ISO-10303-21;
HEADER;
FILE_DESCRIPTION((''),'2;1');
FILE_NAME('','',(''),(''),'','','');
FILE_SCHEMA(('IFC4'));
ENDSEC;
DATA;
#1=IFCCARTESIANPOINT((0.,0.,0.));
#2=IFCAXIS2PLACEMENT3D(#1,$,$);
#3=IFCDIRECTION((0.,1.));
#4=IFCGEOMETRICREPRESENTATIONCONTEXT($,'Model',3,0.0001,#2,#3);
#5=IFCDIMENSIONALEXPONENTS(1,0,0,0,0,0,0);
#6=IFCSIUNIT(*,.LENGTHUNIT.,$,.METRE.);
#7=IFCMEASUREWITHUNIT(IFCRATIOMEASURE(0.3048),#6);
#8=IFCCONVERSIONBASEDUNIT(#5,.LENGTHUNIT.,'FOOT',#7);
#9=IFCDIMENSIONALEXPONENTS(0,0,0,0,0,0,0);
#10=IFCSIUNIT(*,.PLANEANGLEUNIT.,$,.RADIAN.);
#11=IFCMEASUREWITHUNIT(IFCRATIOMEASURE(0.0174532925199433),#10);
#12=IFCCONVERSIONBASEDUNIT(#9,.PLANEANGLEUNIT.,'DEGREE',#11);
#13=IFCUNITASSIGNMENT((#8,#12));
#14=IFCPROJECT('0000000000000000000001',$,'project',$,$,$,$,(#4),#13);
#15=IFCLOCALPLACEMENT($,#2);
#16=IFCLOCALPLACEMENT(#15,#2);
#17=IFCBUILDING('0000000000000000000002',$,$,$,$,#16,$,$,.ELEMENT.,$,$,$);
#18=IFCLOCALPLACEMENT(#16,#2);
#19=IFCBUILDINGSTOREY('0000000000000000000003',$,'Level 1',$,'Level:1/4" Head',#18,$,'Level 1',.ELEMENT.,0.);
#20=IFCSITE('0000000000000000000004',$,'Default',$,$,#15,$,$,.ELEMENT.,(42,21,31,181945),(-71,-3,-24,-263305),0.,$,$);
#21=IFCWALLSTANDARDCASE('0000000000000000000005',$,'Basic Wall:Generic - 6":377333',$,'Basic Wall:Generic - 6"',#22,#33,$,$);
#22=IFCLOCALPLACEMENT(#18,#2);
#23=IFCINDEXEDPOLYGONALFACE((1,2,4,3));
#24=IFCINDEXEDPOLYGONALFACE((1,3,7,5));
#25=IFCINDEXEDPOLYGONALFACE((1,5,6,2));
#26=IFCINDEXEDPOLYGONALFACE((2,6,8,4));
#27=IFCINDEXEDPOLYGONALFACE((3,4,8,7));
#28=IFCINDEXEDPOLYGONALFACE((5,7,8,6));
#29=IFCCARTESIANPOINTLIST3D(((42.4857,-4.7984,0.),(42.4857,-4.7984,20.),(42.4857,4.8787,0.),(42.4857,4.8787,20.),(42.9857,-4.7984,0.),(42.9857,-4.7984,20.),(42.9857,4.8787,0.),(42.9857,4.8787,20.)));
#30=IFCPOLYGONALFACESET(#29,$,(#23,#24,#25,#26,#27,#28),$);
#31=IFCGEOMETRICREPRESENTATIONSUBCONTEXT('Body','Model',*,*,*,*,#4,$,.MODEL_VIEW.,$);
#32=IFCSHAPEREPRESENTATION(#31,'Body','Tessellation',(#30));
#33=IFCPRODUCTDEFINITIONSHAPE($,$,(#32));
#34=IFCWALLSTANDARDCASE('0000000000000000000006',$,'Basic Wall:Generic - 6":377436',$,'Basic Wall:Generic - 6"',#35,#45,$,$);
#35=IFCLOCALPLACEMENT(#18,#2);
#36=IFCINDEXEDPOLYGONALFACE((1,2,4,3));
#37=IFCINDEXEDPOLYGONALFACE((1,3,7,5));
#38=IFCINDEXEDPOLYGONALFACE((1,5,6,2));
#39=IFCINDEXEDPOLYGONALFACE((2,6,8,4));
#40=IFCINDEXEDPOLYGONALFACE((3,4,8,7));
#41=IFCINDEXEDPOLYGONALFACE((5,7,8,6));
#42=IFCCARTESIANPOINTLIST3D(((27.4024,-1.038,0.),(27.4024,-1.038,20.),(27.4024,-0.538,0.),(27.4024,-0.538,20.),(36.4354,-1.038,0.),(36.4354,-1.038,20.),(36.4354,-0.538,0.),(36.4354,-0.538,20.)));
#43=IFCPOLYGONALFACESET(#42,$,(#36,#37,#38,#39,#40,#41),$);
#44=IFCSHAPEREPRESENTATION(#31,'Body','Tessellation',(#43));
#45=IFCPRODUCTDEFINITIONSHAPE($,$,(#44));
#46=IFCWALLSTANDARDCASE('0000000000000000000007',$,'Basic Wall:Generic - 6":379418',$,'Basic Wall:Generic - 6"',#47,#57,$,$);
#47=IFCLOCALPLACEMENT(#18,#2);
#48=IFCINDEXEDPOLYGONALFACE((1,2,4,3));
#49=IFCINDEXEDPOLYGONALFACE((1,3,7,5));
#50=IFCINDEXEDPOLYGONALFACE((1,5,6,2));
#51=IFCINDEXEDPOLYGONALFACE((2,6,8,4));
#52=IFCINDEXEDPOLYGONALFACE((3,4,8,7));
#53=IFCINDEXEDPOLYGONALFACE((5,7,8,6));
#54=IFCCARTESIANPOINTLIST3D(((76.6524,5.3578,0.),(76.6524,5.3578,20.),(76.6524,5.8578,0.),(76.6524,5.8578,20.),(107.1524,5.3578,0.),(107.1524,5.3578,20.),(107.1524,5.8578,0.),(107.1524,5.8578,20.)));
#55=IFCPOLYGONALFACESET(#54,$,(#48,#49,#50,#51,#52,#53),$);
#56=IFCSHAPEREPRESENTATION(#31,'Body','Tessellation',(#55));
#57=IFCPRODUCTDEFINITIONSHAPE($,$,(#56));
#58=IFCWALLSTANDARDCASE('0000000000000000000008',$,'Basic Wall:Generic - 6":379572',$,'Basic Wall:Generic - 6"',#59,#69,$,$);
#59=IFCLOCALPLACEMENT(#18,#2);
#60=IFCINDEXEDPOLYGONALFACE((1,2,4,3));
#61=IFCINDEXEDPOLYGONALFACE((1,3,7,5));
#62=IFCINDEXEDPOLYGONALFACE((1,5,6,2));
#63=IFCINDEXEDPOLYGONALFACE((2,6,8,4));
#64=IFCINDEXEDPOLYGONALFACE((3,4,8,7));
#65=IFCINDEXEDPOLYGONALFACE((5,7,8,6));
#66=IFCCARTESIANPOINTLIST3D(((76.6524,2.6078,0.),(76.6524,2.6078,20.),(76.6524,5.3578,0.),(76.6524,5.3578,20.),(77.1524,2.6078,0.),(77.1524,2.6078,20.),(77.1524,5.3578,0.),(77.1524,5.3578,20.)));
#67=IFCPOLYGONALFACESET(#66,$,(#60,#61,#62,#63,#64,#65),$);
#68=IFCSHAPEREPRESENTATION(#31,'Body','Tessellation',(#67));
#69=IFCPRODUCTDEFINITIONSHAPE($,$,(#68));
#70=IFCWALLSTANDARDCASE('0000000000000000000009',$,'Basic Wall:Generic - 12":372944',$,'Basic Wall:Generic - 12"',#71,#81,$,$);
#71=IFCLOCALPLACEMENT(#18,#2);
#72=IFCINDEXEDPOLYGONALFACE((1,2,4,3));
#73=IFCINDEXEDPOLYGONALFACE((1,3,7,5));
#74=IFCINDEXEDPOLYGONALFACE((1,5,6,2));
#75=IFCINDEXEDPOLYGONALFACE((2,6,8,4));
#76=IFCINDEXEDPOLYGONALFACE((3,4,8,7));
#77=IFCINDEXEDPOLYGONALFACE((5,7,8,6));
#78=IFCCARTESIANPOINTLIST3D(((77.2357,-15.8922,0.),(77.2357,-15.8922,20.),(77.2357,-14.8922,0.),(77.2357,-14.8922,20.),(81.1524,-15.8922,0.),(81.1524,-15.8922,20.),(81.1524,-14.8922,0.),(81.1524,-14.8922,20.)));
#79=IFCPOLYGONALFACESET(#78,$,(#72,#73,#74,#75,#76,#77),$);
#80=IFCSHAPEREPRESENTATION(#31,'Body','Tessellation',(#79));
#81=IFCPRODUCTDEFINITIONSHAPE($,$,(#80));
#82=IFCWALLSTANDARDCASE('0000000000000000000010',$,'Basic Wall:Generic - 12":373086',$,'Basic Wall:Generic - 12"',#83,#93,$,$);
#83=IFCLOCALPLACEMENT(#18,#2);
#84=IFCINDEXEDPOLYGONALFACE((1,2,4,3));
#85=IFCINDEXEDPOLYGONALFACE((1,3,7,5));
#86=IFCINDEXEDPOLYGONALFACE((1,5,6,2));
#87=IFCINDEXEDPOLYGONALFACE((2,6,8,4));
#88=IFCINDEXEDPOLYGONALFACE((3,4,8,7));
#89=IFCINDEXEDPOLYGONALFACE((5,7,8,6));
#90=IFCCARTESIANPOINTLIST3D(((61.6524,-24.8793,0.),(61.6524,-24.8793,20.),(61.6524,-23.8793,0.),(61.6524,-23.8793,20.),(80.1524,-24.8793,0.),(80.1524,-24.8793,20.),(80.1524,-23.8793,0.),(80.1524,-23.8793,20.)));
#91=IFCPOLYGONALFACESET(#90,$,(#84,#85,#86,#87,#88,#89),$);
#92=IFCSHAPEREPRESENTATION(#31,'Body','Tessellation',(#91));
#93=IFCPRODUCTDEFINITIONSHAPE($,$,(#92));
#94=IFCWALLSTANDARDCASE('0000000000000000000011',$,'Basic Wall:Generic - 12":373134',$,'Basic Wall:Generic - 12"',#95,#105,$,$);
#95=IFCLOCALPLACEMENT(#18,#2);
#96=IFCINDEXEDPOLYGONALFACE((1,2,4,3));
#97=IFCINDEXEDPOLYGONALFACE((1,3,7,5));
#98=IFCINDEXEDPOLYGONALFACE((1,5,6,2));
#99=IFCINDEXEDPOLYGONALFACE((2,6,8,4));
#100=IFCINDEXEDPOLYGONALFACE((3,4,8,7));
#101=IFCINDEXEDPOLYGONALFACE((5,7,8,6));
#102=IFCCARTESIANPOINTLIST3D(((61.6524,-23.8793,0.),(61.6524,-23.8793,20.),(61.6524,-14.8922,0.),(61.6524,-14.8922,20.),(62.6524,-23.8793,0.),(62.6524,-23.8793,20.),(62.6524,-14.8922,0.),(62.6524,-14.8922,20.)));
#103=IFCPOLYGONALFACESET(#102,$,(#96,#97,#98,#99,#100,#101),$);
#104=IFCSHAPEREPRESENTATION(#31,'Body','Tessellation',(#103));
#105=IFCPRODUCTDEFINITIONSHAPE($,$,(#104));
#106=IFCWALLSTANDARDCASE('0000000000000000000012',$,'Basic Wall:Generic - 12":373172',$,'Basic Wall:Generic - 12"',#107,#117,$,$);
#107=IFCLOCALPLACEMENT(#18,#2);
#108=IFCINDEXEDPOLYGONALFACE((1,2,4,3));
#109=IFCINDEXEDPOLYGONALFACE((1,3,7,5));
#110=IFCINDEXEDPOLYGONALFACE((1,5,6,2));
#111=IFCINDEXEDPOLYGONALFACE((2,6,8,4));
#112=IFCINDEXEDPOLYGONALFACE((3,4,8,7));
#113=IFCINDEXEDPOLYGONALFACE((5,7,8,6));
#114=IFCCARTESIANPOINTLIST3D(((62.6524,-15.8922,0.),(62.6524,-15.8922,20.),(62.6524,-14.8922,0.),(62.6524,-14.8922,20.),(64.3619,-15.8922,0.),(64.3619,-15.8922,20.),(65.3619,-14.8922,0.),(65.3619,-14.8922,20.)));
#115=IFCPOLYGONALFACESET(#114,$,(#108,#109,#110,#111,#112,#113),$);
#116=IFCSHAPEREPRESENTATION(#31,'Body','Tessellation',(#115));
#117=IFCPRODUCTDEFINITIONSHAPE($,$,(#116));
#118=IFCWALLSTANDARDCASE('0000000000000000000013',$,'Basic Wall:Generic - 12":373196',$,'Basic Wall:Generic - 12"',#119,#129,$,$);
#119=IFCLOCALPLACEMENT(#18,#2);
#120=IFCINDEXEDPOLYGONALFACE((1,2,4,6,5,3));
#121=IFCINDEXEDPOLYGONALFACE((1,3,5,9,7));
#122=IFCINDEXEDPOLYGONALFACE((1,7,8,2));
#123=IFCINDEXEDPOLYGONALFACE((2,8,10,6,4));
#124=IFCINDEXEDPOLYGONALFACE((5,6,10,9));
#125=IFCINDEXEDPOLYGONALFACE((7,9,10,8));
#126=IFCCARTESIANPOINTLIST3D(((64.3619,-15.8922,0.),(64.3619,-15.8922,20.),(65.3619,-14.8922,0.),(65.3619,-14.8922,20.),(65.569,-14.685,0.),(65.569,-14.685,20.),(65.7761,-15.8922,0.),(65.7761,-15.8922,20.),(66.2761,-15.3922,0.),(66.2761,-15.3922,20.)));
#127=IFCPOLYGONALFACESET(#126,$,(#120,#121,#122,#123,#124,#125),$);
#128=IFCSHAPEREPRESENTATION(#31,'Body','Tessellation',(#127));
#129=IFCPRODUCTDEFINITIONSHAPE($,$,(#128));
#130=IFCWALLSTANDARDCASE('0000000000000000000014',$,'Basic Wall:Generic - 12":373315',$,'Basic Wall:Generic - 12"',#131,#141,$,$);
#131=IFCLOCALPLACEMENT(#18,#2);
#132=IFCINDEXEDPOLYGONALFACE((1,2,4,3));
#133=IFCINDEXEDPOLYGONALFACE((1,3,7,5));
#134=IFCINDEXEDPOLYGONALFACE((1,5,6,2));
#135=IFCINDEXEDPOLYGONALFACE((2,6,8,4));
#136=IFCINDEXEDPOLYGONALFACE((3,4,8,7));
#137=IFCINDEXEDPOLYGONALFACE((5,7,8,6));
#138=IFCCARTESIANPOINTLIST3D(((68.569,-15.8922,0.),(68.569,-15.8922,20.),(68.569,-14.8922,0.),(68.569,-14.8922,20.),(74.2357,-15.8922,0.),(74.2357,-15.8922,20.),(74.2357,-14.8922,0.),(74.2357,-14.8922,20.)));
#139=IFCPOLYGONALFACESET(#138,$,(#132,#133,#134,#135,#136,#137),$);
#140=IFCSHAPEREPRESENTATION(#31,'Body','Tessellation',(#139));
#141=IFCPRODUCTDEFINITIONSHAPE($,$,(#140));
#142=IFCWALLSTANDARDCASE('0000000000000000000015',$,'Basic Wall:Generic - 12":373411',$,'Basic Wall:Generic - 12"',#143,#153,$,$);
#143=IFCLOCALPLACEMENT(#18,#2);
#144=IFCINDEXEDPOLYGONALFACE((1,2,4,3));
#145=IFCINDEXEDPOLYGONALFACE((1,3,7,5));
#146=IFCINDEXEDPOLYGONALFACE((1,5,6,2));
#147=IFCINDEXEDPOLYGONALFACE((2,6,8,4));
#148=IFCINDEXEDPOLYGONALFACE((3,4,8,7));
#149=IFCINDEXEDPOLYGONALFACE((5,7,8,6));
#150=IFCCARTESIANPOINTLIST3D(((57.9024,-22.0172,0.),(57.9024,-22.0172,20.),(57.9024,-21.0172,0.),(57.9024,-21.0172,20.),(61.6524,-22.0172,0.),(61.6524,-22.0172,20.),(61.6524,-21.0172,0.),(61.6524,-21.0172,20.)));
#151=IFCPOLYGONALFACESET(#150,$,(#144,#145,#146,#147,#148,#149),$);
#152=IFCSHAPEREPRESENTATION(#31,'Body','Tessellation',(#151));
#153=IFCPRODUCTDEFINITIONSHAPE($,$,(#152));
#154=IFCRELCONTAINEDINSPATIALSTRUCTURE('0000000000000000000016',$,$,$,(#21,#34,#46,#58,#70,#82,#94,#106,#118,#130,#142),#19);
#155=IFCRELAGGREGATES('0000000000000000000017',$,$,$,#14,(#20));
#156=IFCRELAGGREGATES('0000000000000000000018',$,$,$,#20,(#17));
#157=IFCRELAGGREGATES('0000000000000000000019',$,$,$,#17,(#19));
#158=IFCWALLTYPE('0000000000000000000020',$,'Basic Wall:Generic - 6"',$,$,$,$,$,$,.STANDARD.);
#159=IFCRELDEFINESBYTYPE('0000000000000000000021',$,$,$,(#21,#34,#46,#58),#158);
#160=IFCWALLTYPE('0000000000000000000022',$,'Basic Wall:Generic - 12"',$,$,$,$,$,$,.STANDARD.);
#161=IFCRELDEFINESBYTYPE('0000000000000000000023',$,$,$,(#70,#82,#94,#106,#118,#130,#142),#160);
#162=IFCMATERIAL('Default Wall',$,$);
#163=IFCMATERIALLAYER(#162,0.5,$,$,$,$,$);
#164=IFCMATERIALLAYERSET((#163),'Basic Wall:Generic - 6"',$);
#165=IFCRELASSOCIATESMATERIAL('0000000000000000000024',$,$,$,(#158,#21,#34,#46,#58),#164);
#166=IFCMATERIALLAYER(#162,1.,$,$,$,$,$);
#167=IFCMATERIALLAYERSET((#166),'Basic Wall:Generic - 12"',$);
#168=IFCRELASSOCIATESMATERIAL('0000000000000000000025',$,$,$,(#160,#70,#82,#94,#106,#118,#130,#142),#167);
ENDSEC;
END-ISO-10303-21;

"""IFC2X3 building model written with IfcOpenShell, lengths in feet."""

from ifc_helpers import new_model, entity, si_unit, converted_unit, direction, frame, frame_2d, origin, place, context, subcontext, project, spatial, polyline, rectangle, outline, extrude, material, layer, layer_set, layer_usage, type_object, element, save


model = new_model("IFC2X3")

# Units and contexts
model_context = context("Model", 3, precision=0.0001, world=origin(), true_north=direction((0.0, 1.0)))
body_context = subcontext(model_context, "Body", "Model", "MODEL_VIEW")
ifc_project = project(units=[converted_unit("LENGTHUNIT", "FOOT", entity("IfcRatioMeasure", 0.3048), si_unit("LENGTHUNIT", "METRE"), dimensions=[1, 0, 0, 0, 0, 0, 0]), converted_unit("PLANEANGLEUNIT", "DEGREE", entity("IfcRatioMeasure", 0.0174532925199433), si_unit("PLANEANGLEUNIT", "RADIAN"), dimensions=[0, 0, 0, 0, 0, 0, 0])], contexts=[model_context])

# Site, building, storey
site_placement = place(None, origin())
site = spatial("IfcSite", under=ifc_project, at=site_placement, Name="Default", CompositionType="ELEMENT", RefLatitude=(42, 21, 31, 181945), RefLongitude=(-71, -3, -24, -263305), RefElevation=0.0)
building_placement = place(site_placement, origin())
building = spatial("IfcBuilding", under=site, at=building_placement, CompositionType="ELEMENT")
storey_placement = place(building_placement, origin())
storey = spatial("IfcBuildingStorey", under=building, at=storey_placement, Name="Level 1", ObjectType="Level:1/4\" Head", LongName="Level 1", CompositionType="ELEMENT", Elevation=0.0)

# Walls
ifc_material = material(Name="Default Wall")
ifc_layer_1 = layer(ifc_material, 0.5)
ifc_layer_set_1 = layer_set([ifc_layer_1], Name="Basic Wall:Generic - 6\"")
wall_type_1 = type_object("IfcWallType", Name="Basic Wall:Generic - 6\"", PredefinedType="STANDARD", material=ifc_layer_set_1)
ifc_layer_usage_1 = layer_usage(ifc_layer_set_1, "AXIS2", "NEGATIVE", 0.25)
wall_1_placement = place(storey_placement, frame((42.7357, -4.7984, 0.0), z_axis=(0.0, 0.0, 1.0), x_axis=(0.0, 1.0, 0.0)))
element("IfcWallStandardCase", 1, at=wall_1_placement, inside=storey, type_object=wall_type_1, material=ifc_layer_usage_1, Name="Basic Wall:Generic - 6\":377333", ObjectType="Basic Wall:Generic - 6\"", context=body_context, shape_type="SweptSolid", body=[
    extrude(rectangle(XDim=9.6771, YDim=0.5, at=frame_2d((4.8385, 0.0), x_axis=(-1.0, 0.0))), origin(), (0.0, 0.0, 1.0), 20.0),
])
ifc_layer_usage_2 = layer_usage(ifc_layer_set_1, "AXIS2", "NEGATIVE", 0.25)
wall_2_placement = place(storey_placement, frame((36.4354, -0.788, 0.0), z_axis=(0.0, 0.0, 1.0), x_axis=(-1.0, 0.0, 0.0)))
element("IfcWallStandardCase", 2, at=wall_2_placement, inside=storey, type_object=wall_type_1, material=ifc_layer_usage_2, Name="Basic Wall:Generic - 6\":377436", ObjectType="Basic Wall:Generic - 6\"", context=body_context, shape_type="SweptSolid", body=[
    extrude(rectangle(XDim=9.0331, YDim=0.5, at=frame_2d((4.5165, 0.0), x_axis=(-1.0, 0.0))), origin(), (0.0, 0.0, 1.0), 20.0),
])
ifc_layer_usage_3 = layer_usage(ifc_layer_set_1, "AXIS2", "NEGATIVE", 0.25)
wall_3_placement = place(storey_placement, frame((76.6524, 5.6078, 0.0)))
element("IfcWallStandardCase", 3, at=wall_3_placement, inside=storey, type_object=wall_type_1, material=ifc_layer_usage_3, Name="Basic Wall:Generic - 6\":379418", ObjectType="Basic Wall:Generic - 6\"", context=body_context, shape_type="SweptSolid", body=[
    extrude(rectangle(XDim=30.5, YDim=0.5, at=frame_2d((15.25, 0.0), x_axis=(-1.0, 0.0))), origin(), (0.0, 0.0, 1.0), 20.0),
])
ifc_layer_usage_4 = layer_usage(ifc_layer_set_1, "AXIS2", "NEGATIVE", 0.25)
wall_4_placement = place(storey_placement, frame((76.9024, 2.6078, 0.0), z_axis=(0.0, 0.0, 1.0), x_axis=(0.0, 1.0, 0.0)))
element("IfcWallStandardCase", 4, at=wall_4_placement, inside=storey, type_object=wall_type_1, material=ifc_layer_usage_4, Name="Basic Wall:Generic - 6\":379572", ObjectType="Basic Wall:Generic - 6\"", context=body_context, shape_type="SweptSolid", body=[
    extrude(rectangle(XDim=2.75, YDim=0.5, at=frame_2d((1.375, 0.0), x_axis=(-1.0, 0.0))), origin(), (0.0, 0.0, 1.0), 20.0),
])
ifc_layer_2 = layer(ifc_material, 1.0)
ifc_layer_set_2 = layer_set([ifc_layer_2], Name="Basic Wall:Generic - 12\"")
ifc_layer_usage_5 = layer_usage(ifc_layer_set_2, "AXIS2", "NEGATIVE", 0.5)
wall_type_2 = type_object("IfcWallType", Name="Basic Wall:Generic - 12\"", PredefinedType="STANDARD", material=ifc_layer_set_2)
wall_5_placement = place(storey_placement, frame((77.2357, -15.3922, 0.0)))
element("IfcWallStandardCase", 5, at=wall_5_placement, inside=storey, type_object=wall_type_2, material=ifc_layer_usage_5, Name="Basic Wall:Generic - 12\":372944", ObjectType="Basic Wall:Generic - 12\"", context=body_context, shape_type="SweptSolid", body=[
    extrude(rectangle(XDim=3.9167, YDim=1.0, at=frame_2d((1.9583, 0.0), x_axis=(-1.0, 0.0))), origin(), (0.0, 0.0, 1.0), 20.0),
])
ifc_layer_usage_6 = layer_usage(ifc_layer_set_2, "AXIS2", "NEGATIVE", 0.5)
wall_6_placement = place(storey_placement, frame((80.1524, -24.3793, 0.0), z_axis=(0.0, 0.0, 1.0), x_axis=(-1.0, 0.0, 0.0)))
element("IfcWallStandardCase", 6, at=wall_6_placement, inside=storey, type_object=wall_type_2, material=ifc_layer_usage_6, Name="Basic Wall:Generic - 12\":373086", ObjectType="Basic Wall:Generic - 12\"", context=body_context, shape_type="SweptSolid", body=[
    extrude(rectangle(XDim=18.5, YDim=1.0, at=frame_2d((9.25, 0.0), x_axis=(-1.0, 0.0))), origin(), (0.0, 0.0, 1.0), 20.0),
])
ifc_layer_usage_7 = layer_usage(ifc_layer_set_2, "AXIS2", "NEGATIVE", 0.5)
wall_7_placement = place(storey_placement, frame((62.1524, -23.8793, 0.0), z_axis=(0.0, 0.0, 1.0), x_axis=(0.0, 1.0, 0.0)))
element("IfcWallStandardCase", 7, at=wall_7_placement, inside=storey, type_object=wall_type_2, material=ifc_layer_usage_7, Name="Basic Wall:Generic - 12\":373134", ObjectType="Basic Wall:Generic - 12\"", context=body_context, shape_type="SweptSolid", body=[
    extrude(rectangle(XDim=8.9871, YDim=1.0, at=frame_2d((4.4936, 0.0), x_axis=(-1.0, 0.0))), origin(), (0.0, 0.0, 1.0), 20.0),
])
ifc_layer_usage_8 = layer_usage(ifc_layer_set_2, "AXIS2", "NEGATIVE", 0.5)
wall_8_placement = place(storey_placement, frame((62.6524, -15.3922, 0.0)))
element("IfcWallStandardCase", 8, at=wall_8_placement, inside=storey, type_object=wall_type_2, material=ifc_layer_usage_8, Name="Basic Wall:Generic - 12\":373172", ObjectType="Basic Wall:Generic - 12\"", context=body_context, shape_type="SweptSolid", body=[
    extrude(outline(polyline([(1.7096, -0.5), (2.7096, 0.5), (0.0, 0.5), (0.0, -0.5), (1.7096, -0.5)])), origin(), (0.0, 0.0, 1.0), 20.0),
])
ifc_layer_usage_9 = layer_usage(ifc_layer_set_2, "AXIS2", "NEGATIVE", 0.5)
wall_9_placement = place(storey_placement, frame((64.7155, -16.2457, 0.0), z_axis=(0.0, 0.0, 1.0), x_axis=(0.707107, 0.707107, 0.0)))
element("IfcWallStandardCase", 9, at=wall_9_placement, inside=storey, type_object=wall_type_2, material=ifc_layer_usage_9, Name="Basic Wall:Generic - 12\":373196", ObjectType="Basic Wall:Generic - 12\"", context=body_context, shape_type="SweptSolid", body=[
    extrude(outline(polyline([(1.7071, -0.5), (1.7071, 0.5), (1.4142, 0.5), (0.0, 0.5), (1.0, -0.5), (1.7071, -0.5)])), origin(), (0.0, 0.0, 1.0), 20.0),
])
ifc_layer_usage_10 = layer_usage(ifc_layer_set_2, "AXIS2", "NEGATIVE", 0.5)
wall_10_placement = place(storey_placement, frame((68.569, -15.3922, 0.0)))
element("IfcWallStandardCase", 10, at=wall_10_placement, inside=storey, type_object=wall_type_2, material=ifc_layer_usage_10, Name="Basic Wall:Generic - 12\":373315", ObjectType="Basic Wall:Generic - 12\"", context=body_context, shape_type="SweptSolid", body=[
    extrude(rectangle(XDim=5.6667, YDim=1.0, at=frame_2d((2.8333, 0.0), x_axis=(-1.0, 0.0))), origin(), (0.0, 0.0, 1.0), 20.0),
])
ifc_layer_usage_11 = layer_usage(ifc_layer_set_2, "AXIS2", "NEGATIVE", 0.5)
wall_11_placement = place(storey_placement, frame((57.9024, -21.5172, 0.0)))
element("IfcWallStandardCase", 11, at=wall_11_placement, inside=storey, type_object=wall_type_2, material=ifc_layer_usage_11, Name="Basic Wall:Generic - 12\":373411", ObjectType="Basic Wall:Generic - 12\"", context=body_context, shape_type="SweptSolid", body=[
    extrude(rectangle(XDim=3.75, YDim=1.0, at=frame_2d((1.875, 0.0), x_axis=(-1.0, 0.0))), origin(), (0.0, 0.0, 1.0), 20.0),
])

save(model, "model.ifc")
